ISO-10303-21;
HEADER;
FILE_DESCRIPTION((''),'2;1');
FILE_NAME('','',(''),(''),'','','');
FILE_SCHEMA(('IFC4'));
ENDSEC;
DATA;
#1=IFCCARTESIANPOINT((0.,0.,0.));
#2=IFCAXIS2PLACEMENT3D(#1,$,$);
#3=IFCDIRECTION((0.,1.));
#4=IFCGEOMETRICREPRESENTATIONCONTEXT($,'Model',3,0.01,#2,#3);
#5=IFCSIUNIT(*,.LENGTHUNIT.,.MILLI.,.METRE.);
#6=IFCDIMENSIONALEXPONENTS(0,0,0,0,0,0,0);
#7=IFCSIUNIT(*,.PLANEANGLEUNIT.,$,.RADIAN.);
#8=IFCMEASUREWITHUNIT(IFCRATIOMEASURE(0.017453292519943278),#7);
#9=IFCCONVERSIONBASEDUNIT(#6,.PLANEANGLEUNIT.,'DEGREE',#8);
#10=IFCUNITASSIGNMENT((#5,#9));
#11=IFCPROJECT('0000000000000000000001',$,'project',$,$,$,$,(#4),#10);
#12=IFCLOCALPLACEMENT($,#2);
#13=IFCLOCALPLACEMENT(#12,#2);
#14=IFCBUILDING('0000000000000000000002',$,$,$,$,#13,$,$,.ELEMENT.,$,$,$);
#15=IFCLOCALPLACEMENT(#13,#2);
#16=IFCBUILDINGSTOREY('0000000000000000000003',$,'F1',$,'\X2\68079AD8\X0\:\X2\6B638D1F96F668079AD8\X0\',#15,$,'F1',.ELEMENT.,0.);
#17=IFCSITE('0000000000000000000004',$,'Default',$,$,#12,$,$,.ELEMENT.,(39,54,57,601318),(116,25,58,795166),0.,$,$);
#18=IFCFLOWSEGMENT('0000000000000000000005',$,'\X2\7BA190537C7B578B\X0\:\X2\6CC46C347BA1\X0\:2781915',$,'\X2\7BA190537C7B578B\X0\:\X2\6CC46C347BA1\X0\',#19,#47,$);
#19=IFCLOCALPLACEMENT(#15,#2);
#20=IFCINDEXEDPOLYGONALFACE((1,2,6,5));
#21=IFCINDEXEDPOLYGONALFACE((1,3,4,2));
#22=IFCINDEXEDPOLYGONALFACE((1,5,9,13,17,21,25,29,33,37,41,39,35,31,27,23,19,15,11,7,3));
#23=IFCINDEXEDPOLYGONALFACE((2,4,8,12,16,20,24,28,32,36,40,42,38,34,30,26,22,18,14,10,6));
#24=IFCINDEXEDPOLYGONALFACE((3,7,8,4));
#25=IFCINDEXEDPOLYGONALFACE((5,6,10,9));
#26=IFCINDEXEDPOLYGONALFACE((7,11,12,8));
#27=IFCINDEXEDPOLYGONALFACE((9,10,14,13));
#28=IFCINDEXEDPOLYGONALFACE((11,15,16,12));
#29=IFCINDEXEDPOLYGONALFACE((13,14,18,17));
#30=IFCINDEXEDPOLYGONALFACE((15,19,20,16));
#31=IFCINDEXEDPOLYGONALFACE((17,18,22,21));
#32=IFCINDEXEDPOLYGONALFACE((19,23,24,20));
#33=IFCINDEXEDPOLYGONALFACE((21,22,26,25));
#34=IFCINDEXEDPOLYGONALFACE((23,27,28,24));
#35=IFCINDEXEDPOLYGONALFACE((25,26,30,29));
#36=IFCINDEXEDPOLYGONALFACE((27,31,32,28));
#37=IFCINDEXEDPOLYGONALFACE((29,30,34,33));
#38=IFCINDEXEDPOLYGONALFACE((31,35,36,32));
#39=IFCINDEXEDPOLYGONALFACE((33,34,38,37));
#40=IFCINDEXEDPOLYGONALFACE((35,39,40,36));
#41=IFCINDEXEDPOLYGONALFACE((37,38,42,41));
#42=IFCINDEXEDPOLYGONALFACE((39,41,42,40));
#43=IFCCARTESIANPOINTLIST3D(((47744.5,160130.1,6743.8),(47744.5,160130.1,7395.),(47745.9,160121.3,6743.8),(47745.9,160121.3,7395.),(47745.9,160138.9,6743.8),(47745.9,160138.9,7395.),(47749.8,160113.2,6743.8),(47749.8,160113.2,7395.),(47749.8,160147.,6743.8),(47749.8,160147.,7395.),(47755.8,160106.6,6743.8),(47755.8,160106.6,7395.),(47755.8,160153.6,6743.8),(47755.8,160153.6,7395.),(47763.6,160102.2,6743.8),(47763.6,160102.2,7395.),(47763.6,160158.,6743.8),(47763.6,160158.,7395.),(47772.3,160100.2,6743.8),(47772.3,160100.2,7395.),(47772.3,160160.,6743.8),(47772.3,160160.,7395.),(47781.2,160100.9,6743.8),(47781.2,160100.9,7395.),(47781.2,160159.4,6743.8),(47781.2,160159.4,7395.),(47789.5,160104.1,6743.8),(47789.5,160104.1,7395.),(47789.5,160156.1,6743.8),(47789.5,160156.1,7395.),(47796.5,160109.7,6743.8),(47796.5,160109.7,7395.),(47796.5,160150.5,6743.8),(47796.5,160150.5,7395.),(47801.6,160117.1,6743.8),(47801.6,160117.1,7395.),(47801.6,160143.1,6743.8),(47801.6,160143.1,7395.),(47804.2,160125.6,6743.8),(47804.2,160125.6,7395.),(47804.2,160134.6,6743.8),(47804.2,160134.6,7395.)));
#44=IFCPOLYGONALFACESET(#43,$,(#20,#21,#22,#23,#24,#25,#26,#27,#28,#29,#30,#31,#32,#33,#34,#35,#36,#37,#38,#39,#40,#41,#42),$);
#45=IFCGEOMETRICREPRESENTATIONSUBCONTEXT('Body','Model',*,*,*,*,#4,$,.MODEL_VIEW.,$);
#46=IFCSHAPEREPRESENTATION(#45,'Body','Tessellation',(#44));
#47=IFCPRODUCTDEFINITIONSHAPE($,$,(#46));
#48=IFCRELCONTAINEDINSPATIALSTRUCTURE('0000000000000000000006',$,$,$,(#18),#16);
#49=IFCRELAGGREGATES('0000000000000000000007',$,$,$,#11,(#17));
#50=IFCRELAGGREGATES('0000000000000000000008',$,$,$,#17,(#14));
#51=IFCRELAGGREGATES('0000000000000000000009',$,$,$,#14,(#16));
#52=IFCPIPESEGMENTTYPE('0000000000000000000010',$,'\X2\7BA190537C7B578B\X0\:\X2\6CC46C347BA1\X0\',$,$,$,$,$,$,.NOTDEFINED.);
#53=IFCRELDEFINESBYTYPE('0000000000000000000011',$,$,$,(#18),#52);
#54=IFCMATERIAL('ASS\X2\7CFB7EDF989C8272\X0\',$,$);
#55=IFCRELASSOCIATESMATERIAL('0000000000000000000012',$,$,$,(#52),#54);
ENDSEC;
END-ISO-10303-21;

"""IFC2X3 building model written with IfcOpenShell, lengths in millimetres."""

from ifc_helpers import new_model, entity, si_unit, converted_unit, direction, frame, frame_2d, origin, place, context, subcontext, project, spatial, circle, extrude, material, type_object, element, save


model = new_model("IFC2X3")

# Units and contexts
model_context = context("Model", 3, precision=0.01, world=origin(), true_north=direction((0.0, 1.0)))
body_context = subcontext(model_context, "Body", "Model", "MODEL_VIEW")
ifc_project = project(units=[si_unit("LENGTHUNIT", "METRE", prefix="MILLI"), converted_unit("PLANEANGLEUNIT", "DEGREE", entity("IfcRatioMeasure", 0.017453292519943278), si_unit("PLANEANGLEUNIT", "RADIAN"), dimensions=[0, 0, 0, 0, 0, 0, 0])], contexts=[model_context])

# Site, building, storey
site_placement = place(None, origin())
site = spatial("IfcSite", under=ifc_project, at=site_placement, Name="Default", CompositionType="ELEMENT", RefLatitude=(39, 54, 57, 601318), RefLongitude=(116, 25, 58, 795166), RefElevation=0.0)
building_placement = place(site_placement, origin())
building = spatial("IfcBuilding", under=site, at=building_placement, CompositionType="ELEMENT")
storey_placement = place(building_placement, origin())
storey = spatial("IfcBuildingStorey", under=building, at=storey_placement, Name="F1", ObjectType="标高:正负零标高", LongName="F1", CompositionType="ELEMENT", Elevation=0.0)

# Flow segment
ifc_material_1 = material(Name="ASS系统颜色")
pipe_segment_type_1 = type_object("IfcPipeSegmentType", Name="管道类型:泄水管", PredefinedType="NOTDEFINED", material=ifc_material_1)
flow_segment_1_placement = place(storey_placement, origin())
element("IfcFlowSegment", 1, at=flow_segment_1_placement, inside=storey, type_object=pipe_segment_type_1, Name="管道类型:泄水管:2781915", ObjectType="管道类型:泄水管", context=body_context, shape_type="SweptSolid", body=[
    extrude(circle(Radius=30.0, at=frame_2d((0.0, 0.0), x_axis=(1.0, 0.0))), frame((47774.5, 160130.1, 6743.8), z_axis=(0.0, 0.0, 1.0), x_axis=(-1.0, 0.0, 0.0)), (0.0, 0.0, 1.0), 651.2),
])

save(model, "model.ifc")
